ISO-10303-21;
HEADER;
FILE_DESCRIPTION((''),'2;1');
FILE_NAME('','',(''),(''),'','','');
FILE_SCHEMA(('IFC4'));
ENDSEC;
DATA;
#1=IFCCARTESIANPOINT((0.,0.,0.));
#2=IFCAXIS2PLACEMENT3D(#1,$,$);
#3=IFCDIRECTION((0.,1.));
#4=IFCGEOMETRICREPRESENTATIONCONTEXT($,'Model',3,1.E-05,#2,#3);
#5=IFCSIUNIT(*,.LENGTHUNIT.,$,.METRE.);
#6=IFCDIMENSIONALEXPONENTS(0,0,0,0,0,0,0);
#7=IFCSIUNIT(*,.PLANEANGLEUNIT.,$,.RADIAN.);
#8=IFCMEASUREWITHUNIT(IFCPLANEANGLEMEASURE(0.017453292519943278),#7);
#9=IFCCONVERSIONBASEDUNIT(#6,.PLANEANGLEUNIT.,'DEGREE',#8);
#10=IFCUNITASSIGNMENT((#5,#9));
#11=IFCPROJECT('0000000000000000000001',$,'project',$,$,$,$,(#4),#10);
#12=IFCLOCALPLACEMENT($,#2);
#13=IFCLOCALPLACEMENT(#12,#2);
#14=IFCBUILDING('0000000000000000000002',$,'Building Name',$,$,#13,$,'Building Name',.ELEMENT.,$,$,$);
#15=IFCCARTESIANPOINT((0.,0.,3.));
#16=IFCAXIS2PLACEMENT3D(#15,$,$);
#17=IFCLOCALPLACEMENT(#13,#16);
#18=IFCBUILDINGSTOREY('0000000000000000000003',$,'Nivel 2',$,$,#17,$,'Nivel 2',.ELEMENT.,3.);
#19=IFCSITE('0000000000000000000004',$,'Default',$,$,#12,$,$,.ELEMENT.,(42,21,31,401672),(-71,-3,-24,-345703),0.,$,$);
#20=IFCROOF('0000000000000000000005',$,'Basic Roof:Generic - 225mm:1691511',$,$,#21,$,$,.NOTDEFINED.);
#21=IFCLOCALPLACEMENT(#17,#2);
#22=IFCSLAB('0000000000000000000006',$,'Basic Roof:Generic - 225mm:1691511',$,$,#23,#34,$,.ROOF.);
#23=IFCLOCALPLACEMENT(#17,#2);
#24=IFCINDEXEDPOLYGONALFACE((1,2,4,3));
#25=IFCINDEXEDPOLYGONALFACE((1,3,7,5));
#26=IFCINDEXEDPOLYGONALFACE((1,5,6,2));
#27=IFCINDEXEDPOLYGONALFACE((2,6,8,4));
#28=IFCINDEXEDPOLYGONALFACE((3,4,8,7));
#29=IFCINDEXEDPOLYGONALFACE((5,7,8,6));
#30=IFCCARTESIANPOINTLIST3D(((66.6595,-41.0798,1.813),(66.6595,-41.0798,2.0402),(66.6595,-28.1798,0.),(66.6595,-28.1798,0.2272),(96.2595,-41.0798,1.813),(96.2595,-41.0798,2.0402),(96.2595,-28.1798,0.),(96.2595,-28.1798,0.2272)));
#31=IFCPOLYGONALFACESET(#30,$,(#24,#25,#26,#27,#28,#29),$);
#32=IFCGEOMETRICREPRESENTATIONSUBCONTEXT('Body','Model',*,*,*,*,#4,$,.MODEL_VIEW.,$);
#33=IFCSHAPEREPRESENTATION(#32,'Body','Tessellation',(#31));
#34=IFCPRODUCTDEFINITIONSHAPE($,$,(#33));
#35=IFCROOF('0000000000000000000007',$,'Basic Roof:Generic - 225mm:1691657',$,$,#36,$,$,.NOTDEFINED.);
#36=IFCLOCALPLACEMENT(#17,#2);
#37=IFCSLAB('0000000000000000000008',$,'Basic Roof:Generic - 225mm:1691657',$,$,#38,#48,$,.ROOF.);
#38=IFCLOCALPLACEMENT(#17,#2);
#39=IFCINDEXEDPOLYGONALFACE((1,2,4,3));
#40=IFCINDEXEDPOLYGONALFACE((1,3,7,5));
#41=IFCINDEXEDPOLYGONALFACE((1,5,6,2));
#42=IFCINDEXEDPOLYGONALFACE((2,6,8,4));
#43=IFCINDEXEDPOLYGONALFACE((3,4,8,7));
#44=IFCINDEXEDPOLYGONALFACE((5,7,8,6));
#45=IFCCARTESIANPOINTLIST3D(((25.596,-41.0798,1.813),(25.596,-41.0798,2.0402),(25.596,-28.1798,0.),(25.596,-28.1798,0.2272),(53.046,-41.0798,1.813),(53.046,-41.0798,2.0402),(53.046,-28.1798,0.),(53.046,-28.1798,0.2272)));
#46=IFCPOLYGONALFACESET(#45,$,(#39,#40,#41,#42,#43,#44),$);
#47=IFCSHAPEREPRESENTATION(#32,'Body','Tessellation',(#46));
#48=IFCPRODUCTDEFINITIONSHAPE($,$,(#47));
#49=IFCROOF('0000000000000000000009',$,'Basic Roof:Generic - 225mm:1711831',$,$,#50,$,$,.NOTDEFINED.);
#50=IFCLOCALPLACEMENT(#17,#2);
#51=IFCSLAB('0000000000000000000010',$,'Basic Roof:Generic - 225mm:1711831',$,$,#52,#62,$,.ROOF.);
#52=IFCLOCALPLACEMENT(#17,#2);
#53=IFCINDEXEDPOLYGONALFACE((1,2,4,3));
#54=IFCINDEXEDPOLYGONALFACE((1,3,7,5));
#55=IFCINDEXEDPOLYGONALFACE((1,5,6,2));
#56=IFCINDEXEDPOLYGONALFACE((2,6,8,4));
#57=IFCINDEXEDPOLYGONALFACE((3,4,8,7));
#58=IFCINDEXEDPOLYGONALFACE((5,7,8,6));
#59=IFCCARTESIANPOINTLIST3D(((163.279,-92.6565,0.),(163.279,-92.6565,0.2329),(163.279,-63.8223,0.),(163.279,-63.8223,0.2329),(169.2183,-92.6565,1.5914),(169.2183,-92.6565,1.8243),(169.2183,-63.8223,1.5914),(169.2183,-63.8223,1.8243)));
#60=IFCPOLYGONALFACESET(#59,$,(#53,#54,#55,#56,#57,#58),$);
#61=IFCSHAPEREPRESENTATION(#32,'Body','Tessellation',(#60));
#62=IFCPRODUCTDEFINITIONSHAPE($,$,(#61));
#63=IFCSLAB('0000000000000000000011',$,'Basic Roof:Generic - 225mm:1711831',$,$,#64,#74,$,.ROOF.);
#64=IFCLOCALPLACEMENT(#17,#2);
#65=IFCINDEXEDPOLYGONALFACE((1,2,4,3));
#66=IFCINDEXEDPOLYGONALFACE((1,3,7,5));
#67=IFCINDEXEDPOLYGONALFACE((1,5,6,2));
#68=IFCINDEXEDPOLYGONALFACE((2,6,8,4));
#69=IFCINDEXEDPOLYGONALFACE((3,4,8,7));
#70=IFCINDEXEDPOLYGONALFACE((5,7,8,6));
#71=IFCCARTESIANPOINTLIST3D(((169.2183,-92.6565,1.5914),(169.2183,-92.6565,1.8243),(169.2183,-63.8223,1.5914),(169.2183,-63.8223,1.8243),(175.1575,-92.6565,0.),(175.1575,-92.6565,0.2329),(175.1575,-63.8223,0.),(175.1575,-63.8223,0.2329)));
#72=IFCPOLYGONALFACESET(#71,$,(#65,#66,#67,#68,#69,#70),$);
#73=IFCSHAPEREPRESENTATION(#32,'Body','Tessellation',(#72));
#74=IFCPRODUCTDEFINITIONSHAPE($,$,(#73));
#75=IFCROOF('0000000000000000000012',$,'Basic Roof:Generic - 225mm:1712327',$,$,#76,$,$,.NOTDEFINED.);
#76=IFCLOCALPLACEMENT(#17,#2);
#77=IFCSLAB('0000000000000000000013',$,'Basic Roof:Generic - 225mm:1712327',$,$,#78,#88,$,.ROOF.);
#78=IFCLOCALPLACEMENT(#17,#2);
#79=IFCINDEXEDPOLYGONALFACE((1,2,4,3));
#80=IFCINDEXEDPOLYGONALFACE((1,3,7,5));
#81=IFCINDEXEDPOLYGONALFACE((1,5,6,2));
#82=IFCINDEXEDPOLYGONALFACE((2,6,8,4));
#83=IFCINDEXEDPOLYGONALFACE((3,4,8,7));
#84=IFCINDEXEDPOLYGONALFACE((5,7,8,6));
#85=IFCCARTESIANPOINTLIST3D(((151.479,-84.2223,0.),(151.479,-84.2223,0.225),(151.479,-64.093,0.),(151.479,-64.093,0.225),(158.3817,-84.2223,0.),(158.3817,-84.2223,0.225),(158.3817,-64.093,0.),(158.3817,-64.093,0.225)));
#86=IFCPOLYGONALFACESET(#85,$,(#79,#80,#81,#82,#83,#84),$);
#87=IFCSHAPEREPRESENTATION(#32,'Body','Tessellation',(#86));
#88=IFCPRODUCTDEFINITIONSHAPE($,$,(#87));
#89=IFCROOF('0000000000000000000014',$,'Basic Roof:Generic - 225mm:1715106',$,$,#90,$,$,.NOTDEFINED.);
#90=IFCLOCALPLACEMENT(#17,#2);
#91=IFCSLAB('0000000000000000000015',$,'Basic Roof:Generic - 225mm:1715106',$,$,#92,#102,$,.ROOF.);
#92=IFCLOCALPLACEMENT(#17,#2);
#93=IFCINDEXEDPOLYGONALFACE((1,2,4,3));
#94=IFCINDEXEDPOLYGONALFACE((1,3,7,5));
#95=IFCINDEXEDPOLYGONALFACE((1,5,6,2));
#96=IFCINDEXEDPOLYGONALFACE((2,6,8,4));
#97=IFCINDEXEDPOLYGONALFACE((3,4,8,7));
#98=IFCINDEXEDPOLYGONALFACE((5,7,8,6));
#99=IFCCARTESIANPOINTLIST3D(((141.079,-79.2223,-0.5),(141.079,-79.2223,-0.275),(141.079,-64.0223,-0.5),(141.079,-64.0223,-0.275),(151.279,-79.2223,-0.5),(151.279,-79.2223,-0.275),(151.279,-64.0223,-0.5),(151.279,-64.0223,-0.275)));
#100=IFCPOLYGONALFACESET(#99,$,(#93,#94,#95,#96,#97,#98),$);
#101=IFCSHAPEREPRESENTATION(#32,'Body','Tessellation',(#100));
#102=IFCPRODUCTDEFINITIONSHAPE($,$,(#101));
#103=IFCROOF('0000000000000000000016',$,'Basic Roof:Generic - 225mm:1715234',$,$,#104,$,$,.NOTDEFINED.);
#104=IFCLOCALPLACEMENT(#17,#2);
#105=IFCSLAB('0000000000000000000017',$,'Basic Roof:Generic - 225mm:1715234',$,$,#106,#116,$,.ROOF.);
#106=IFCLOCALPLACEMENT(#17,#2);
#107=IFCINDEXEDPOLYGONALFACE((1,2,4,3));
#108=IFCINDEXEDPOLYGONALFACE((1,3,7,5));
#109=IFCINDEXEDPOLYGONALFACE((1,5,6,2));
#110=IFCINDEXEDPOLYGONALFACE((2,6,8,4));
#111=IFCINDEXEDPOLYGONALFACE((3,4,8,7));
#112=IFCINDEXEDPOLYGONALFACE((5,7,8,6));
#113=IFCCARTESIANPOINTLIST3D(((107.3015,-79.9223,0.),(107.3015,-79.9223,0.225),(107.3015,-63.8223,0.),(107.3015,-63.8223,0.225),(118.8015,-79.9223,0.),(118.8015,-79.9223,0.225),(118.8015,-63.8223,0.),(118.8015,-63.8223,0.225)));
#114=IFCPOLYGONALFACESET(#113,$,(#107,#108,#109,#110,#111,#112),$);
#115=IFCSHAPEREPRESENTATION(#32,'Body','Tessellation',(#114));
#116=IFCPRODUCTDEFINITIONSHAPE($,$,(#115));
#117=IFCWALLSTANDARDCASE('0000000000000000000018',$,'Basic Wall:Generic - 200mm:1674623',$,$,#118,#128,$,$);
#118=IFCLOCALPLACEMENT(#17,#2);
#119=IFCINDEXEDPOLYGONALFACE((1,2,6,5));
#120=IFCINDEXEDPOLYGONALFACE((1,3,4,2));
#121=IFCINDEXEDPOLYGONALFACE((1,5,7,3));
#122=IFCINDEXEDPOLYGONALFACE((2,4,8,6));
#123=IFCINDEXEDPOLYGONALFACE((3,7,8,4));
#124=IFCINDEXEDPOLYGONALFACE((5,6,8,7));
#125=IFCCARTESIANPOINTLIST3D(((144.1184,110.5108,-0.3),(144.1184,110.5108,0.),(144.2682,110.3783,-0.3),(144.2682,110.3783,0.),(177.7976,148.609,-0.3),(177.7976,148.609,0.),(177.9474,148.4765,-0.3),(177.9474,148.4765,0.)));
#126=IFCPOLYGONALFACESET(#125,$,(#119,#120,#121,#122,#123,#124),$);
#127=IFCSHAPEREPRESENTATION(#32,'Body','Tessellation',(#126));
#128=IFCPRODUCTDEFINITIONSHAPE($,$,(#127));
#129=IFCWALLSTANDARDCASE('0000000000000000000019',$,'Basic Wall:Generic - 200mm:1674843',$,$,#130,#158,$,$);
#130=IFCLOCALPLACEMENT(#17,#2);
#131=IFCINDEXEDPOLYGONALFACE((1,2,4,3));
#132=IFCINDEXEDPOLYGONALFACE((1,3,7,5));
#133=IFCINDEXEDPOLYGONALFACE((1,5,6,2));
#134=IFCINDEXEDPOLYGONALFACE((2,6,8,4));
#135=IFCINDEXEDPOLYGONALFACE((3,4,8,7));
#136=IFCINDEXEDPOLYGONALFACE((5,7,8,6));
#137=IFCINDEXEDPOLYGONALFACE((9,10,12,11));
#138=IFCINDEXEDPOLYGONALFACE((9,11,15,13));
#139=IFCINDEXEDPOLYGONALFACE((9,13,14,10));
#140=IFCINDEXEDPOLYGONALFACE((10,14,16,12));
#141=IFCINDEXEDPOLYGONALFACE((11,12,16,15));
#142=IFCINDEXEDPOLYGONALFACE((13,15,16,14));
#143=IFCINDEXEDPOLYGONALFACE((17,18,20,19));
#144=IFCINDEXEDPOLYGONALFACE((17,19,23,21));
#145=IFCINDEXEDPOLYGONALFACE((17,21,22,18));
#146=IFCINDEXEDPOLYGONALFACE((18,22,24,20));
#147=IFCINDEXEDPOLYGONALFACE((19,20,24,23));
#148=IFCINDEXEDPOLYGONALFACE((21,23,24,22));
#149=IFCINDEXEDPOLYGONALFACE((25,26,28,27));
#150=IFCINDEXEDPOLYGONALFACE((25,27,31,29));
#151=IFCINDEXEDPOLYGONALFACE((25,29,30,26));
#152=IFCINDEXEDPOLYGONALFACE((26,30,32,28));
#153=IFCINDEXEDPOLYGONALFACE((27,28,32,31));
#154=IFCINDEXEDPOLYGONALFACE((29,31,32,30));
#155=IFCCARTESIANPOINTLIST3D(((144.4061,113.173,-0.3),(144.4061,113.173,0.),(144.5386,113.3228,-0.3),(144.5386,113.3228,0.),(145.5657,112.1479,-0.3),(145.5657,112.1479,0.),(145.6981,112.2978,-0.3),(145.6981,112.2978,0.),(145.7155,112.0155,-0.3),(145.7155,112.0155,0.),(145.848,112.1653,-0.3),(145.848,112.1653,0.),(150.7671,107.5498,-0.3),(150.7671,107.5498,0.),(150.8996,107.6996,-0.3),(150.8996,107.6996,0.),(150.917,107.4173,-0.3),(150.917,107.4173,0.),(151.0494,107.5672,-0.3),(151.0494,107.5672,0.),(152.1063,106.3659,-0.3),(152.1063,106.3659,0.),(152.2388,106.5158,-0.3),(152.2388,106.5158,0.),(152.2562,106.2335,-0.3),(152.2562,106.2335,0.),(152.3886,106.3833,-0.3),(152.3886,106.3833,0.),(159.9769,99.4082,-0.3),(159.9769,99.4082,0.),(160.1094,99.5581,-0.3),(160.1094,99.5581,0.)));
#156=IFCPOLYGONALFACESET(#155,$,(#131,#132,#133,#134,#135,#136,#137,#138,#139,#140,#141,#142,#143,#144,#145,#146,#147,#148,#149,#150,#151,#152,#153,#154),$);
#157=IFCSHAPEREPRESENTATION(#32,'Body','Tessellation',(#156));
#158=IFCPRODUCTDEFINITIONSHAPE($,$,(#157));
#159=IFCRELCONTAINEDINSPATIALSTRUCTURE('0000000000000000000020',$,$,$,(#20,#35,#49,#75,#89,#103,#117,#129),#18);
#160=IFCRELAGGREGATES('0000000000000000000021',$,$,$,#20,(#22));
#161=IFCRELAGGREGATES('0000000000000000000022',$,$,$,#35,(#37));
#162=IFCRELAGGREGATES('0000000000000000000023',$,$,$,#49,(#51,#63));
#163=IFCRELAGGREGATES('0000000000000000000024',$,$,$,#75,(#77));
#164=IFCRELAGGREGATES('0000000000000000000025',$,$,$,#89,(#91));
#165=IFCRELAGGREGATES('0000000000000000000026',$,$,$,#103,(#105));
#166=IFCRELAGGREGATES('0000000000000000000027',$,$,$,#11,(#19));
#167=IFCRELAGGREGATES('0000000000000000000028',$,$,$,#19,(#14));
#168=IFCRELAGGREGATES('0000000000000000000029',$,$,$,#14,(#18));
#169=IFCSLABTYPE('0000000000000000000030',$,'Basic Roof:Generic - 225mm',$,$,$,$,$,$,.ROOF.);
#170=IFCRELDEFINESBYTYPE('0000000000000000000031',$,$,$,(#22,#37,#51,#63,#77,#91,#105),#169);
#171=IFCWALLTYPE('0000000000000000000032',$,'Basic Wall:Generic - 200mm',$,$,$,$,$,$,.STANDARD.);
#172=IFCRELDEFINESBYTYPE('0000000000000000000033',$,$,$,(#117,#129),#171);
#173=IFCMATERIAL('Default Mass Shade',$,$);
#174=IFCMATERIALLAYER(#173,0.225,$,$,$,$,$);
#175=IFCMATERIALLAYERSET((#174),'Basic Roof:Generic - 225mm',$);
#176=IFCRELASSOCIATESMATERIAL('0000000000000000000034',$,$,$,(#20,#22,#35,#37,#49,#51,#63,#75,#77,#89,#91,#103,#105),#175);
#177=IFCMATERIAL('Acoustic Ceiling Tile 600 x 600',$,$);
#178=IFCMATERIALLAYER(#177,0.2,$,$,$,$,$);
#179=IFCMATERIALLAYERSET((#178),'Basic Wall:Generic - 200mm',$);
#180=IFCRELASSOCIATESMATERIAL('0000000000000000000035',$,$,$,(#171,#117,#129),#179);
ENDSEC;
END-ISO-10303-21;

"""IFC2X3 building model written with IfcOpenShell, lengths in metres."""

from ifc_helpers import new_model, entity, si_unit, converted_unit, direction, frame, frame_2d, origin, place, context, subcontext, project, spatial, rectangle, extrude, material, layer, layer_set, layer_usage, type_object, element, aggregate, save


model = new_model("IFC2X3")

# Units and contexts
model_context = context("Model", 3, precision=1e-05, world=origin(), true_north=direction((0.0, 1.0)))
body_context = subcontext(model_context, "Body", "Model", "MODEL_VIEW")
ifc_project = project(units=[si_unit("LENGTHUNIT", "METRE"), converted_unit("PLANEANGLEUNIT", "DEGREE", entity("IfcPlaneAngleMeasure", 0.017453292519943278), si_unit("PLANEANGLEUNIT", "RADIAN"), dimensions=[0, 0, 0, 0, 0, 0, 0])], contexts=[model_context])

# Site, building, storey
site_placement = place(None, origin())
site = spatial("IfcSite", under=ifc_project, at=site_placement, Name="Default", CompositionType="ELEMENT", RefLatitude=(42, 21, 31, 401672), RefLongitude=(-71, -3, -24, -345703), RefElevation=0.0)
building_placement = place(site_placement, origin())
building = spatial("IfcBuilding", under=site, at=building_placement, Name="Building Name", LongName="Building Name", CompositionType="ELEMENT")
storey_placement = place(building_placement, frame((0.0, 0.0, 3.0)))
storey = spatial("IfcBuildingStorey", under=building, at=storey_placement, Name="Nivel 2", LongName="Nivel 2", CompositionType="ELEMENT", Elevation=3.0)

# Roofs, slabs
ifc_material_1 = material(Name="Default Mass Shade")
ifc_layer_1 = layer(ifc_material_1, 0.225)
ifc_layer_set_1 = layer_set([ifc_layer_1], Name="Basic Roof:Generic - 225mm")
roof_1_placement = place(storey_placement, frame((66.6595, -41.0798, 0.0)))
roof_1 = element("IfcRoof", 1, at=roof_1_placement, inside=storey, material=ifc_layer_set_1, Name="Basic Roof:Generic - 225mm:1691511", ShapeType="NOTDEFINED")
slab_type = type_object("IfcSlabType", Name="Basic Roof:Generic - 225mm", PredefinedType="ROOF")
slab_1_placement = place(roof_1_placement, origin())
slab_1 = element("IfcSlab", 2, at=slab_1_placement, type_object=slab_type, material=ifc_layer_set_1, Name="Basic Roof:Generic - 225mm:1691511", PredefinedType="ROOF", context=body_context, shape_type="SweptSolid", body=[
    extrude(rectangle(XDim=29.6, YDim=13.0268, at=frame_2d((0.0, 0.0), x_axis=(-1.0, 0.0))), frame((14.8, 6.45, 0.9065), z_axis=(0.0, 0.139173, 0.990268), x_axis=(1.0, 0.0, 0.0)), (0.0, -0.139173, 0.990268), 0.2272),
])
aggregate(roof_1, [slab_1])
roof_2_placement = place(storey_placement, frame((25.596, -41.0798, 0.0)))
roof_2 = element("IfcRoof", 3, at=roof_2_placement, inside=storey, material=ifc_layer_set_1, Name="Basic Roof:Generic - 225mm:1691657", ShapeType="NOTDEFINED")
slab_2_placement = place(roof_2_placement, origin())
slab_2 = element("IfcSlab", 4, at=slab_2_placement, type_object=slab_type, material=ifc_layer_set_1, Name="Basic Roof:Generic - 225mm:1691657", PredefinedType="ROOF", context=body_context, shape_type="SweptSolid", body=[
    extrude(rectangle(XDim=27.45, YDim=13.0268, at=frame_2d((0.0, 0.0), x_axis=(-1.0, 0.0))), frame((13.725, 6.45, 0.9065), z_axis=(0.0, 0.139173, 0.990268), x_axis=(1.0, 0.0, 0.0)), (0.0, -0.139173, 0.990268), 0.2272),
])
aggregate(roof_2, [slab_2])

# Roof, slabs
roof_3_placement = place(storey_placement, frame((163.279, -92.6565, 0.0)))
roof_3 = element("IfcRoof", 5, at=roof_3_placement, inside=storey, material=ifc_layer_set_1, Name="Basic Roof:Generic - 225mm:1711831", ShapeType="NOTDEFINED")
slab_3_placement = place(roof_3_placement, origin())
slab_3 = element("IfcSlab", 6, at=slab_3_placement, type_object=slab_type, material=ifc_layer_set_1, Name="Basic Roof:Generic - 225mm:1711831", PredefinedType="ROOF", context=body_context, shape_type="SweptSolid", body=[
    extrude(rectangle(XDim=28.8342, YDim=6.1487, at=frame_2d((0.0, 0.0), x_axis=(0.0, 1.0))), frame((2.9696, 14.4171, 0.7957), z_axis=(-0.258819, 0.0, 0.965926), x_axis=(0.965926, 0.0, 0.258819)), (0.258819, 0.0, 0.965926), 0.2329),
])
slab_4_placement = place(roof_3_placement, origin())
slab_4 = element("IfcSlab", 7, at=slab_4_placement, type_object=slab_type, material=ifc_layer_set_1, Name="Basic Roof:Generic - 225mm:1711831", PredefinedType="ROOF", context=body_context, shape_type="SweptSolid", body=[
    extrude(rectangle(XDim=6.1487, YDim=28.8342, at=frame_2d((0.0, 0.0), x_axis=(1.0, 0.0))), frame((8.9088, 14.4171, 0.7957), z_axis=(0.258819, 0.0, 0.965926), x_axis=(0.965926, 0.0, -0.258819)), (-0.258819, 0.0, 0.965926), 0.2329),
])
aggregate(roof_3, [slab_3, slab_4])

# Roofs, slabs
roof_4_placement = place(storey_placement, frame((151.479, -84.2223, 0.0)))
roof_4 = element("IfcRoof", 8, at=roof_4_placement, inside=storey, material=ifc_layer_set_1, Name="Basic Roof:Generic - 225mm:1712327", ShapeType="NOTDEFINED")
slab_5_placement = place(roof_4_placement, origin())
slab_5 = element("IfcSlab", 9, at=slab_5_placement, type_object=slab_type, material=ifc_layer_set_1, Name="Basic Roof:Generic - 225mm:1712327", PredefinedType="ROOF", context=body_context, shape_type="SweptSolid", body=[
    extrude(rectangle(XDim=20.1293, YDim=6.9026, at=frame_2d((0.0, 0.0), x_axis=(0.0, -1.0))), frame((3.4513, 10.0646, 0.0)), (0.0, 0.0, 1.0), 0.225),
])
aggregate(roof_4, [slab_5])
roof_5_placement = place(storey_placement, frame((141.079, -79.2223, -0.5)))
roof_5 = element("IfcRoof", 10, at=roof_5_placement, inside=storey, material=ifc_layer_set_1, Name="Basic Roof:Generic - 225mm:1715106", ShapeType="NOTDEFINED")
slab_6_placement = place(roof_5_placement, origin())
slab_6 = element("IfcSlab", 11, at=slab_6_placement, type_object=slab_type, material=ifc_layer_set_1, Name="Basic Roof:Generic - 225mm:1715106", PredefinedType="ROOF", context=body_context, shape_type="SweptSolid", body=[
    extrude(rectangle(XDim=10.2, YDim=15.2, at=frame_2d((0.0, 0.0), x_axis=(-1.0, 0.0))), frame((5.1, 7.6, 0.0)), (0.0, 0.0, 1.0), 0.225),
])
aggregate(roof_5, [slab_6])
roof_6_placement = place(storey_placement, frame((107.3015, -79.9223, 0.0)))
roof_6 = element("IfcRoof", 12, at=roof_6_placement, inside=storey, material=ifc_layer_set_1, Name="Basic Roof:Generic - 225mm:1715234", ShapeType="NOTDEFINED")
slab_7_placement = place(roof_6_placement, origin())
slab_7 = element("IfcSlab", 13, at=slab_7_placement, type_object=slab_type, material=ifc_layer_set_1, Name="Basic Roof:Generic - 225mm:1715234", PredefinedType="ROOF", context=body_context, shape_type="SweptSolid", body=[
    extrude(rectangle(XDim=16.1, YDim=11.5, at=frame_2d((0.0, 0.0), x_axis=(0.0, 1.0))), frame((5.75, 8.05, 0.0)), (0.0, 0.0, 1.0), 0.225),
])
aggregate(roof_6, [slab_7])

# Wall
ifc_material_2 = material(Name="Acoustic Ceiling Tile 600 x 600")
ifc_layer_2 = layer(ifc_material_2, 0.2)
ifc_layer_set_2 = layer_set([ifc_layer_2], Name="Basic Wall:Generic - 200mm")
ifc_layer_usage_1 = layer_usage(ifc_layer_set_2, "AXIS2", "NEGATIVE", 0.1)
wall_type_1 = type_object("IfcWallType", Name="Basic Wall:Generic - 200mm", PredefinedType="STANDARD", material=ifc_layer_set_2)
wall_1_placement = place(storey_placement, frame((144.1933, 110.4446, -0.3), z_axis=(0.0, 0.0, 1.0), x_axis=(0.66232, 0.749221, 0.0)))
element("IfcWallStandardCase", 14, at=wall_1_placement, inside=storey, type_object=wall_type_1, material=ifc_layer_usage_1, Name="Basic Wall:Generic - 200mm:1674623", context=body_context, shape_type="SweptSolid", body=[
    extrude(rectangle(XDim=50.8503, YDim=0.2, at=frame_2d((25.4252, 0.0), x_axis=(-1.0, 0.0))), origin(), (0.0, 0.0, 1.0), 0.3),
])

# Wall, openings
ifc_layer_usage_2 = layer_usage(ifc_layer_set_2, "AXIS2", "NEGATIVE", 0.1)
wall_2_placement = place(storey_placement, frame((160.0432, 99.4831, -0.3), z_axis=(0.0, 0.0, 1.0), x_axis=(-0.749221, 0.66232, 0.0)))
wall_2 = element("IfcWallStandardCase", 15, at=wall_2_placement, inside=storey, type_object=wall_type_1, material=ifc_layer_usage_2, Name="Basic Wall:Generic - 200mm:1674843", context=body_context, shape_type="SweptSolid", body=[
    extrude(rectangle(XDim=20.7826, YDim=0.2, at=frame_2d((10.3913, 0.0), x_axis=(-1.0, 0.0))), origin(), (0.0, 0.0, 1.0), 0.3),
])
opening_1_placement = place(storey_placement, frame((160.0432, 99.4831, -0.3), z_axis=(0.0, 0.0, 1.0), x_axis=(-0.749221, 0.66232, 0.0)))
element("IfcOpeningElement", 16, at=opening_1_placement, cuts=wall_2, ObjectType="Opening", context=body_context, shape_type="SweptSolid", body=[
    extrude(rectangle(XDim=0.3, YDim=0.2, at=frame_2d((0.0, 0.0), x_axis=(1.0, 0.0))), frame((10.305, 0.0, 0.15), z_axis=(1.0, 0.0, 0.0), x_axis=(0.0, 0.0, -1.0)), (0.0, 0.0, 1.0), 0.2),
])
opening_2_placement = place(storey_placement, frame((160.0432, 99.4831, -0.3), z_axis=(0.0, 0.0, 1.0), x_axis=(-0.749221, 0.66232, 0.0)))
element("IfcOpeningElement", 17, at=opening_2_placement, cuts=wall_2, ObjectType="Opening", context=body_context, shape_type="SweptSolid", body=[
    extrude(rectangle(XDim=0.3, YDim=0.2, at=frame_2d((0.0, 0.0), x_axis=(1.0, 0.0))), frame((12.0925, 0.0, 0.15), z_axis=(1.0, 0.0, 0.0), x_axis=(0.0, 0.0, -1.0)), (0.0, 0.0, 1.0), 0.2),
])
opening_3_placement = place(storey_placement, frame((160.0432, 99.4831, -0.3), z_axis=(0.0, 0.0, 1.0), x_axis=(-0.749221, 0.66232, 0.0)))
element("IfcOpeningElement", 18, at=opening_3_placement, cuts=wall_2, ObjectType="Opening", context=body_context, shape_type="SweptSolid", body=[
    extrude(rectangle(XDim=0.3, YDim=0.2, at=frame_2d((0.0, 0.0), x_axis=(1.0, 0.0))), frame((19.035, 0.0, 0.15), z_axis=(1.0, 0.0, 0.0), x_axis=(0.0, 0.0, -1.0)), (0.0, 0.0, 1.0), 0.2),
])

save(model, "model.ifc")
